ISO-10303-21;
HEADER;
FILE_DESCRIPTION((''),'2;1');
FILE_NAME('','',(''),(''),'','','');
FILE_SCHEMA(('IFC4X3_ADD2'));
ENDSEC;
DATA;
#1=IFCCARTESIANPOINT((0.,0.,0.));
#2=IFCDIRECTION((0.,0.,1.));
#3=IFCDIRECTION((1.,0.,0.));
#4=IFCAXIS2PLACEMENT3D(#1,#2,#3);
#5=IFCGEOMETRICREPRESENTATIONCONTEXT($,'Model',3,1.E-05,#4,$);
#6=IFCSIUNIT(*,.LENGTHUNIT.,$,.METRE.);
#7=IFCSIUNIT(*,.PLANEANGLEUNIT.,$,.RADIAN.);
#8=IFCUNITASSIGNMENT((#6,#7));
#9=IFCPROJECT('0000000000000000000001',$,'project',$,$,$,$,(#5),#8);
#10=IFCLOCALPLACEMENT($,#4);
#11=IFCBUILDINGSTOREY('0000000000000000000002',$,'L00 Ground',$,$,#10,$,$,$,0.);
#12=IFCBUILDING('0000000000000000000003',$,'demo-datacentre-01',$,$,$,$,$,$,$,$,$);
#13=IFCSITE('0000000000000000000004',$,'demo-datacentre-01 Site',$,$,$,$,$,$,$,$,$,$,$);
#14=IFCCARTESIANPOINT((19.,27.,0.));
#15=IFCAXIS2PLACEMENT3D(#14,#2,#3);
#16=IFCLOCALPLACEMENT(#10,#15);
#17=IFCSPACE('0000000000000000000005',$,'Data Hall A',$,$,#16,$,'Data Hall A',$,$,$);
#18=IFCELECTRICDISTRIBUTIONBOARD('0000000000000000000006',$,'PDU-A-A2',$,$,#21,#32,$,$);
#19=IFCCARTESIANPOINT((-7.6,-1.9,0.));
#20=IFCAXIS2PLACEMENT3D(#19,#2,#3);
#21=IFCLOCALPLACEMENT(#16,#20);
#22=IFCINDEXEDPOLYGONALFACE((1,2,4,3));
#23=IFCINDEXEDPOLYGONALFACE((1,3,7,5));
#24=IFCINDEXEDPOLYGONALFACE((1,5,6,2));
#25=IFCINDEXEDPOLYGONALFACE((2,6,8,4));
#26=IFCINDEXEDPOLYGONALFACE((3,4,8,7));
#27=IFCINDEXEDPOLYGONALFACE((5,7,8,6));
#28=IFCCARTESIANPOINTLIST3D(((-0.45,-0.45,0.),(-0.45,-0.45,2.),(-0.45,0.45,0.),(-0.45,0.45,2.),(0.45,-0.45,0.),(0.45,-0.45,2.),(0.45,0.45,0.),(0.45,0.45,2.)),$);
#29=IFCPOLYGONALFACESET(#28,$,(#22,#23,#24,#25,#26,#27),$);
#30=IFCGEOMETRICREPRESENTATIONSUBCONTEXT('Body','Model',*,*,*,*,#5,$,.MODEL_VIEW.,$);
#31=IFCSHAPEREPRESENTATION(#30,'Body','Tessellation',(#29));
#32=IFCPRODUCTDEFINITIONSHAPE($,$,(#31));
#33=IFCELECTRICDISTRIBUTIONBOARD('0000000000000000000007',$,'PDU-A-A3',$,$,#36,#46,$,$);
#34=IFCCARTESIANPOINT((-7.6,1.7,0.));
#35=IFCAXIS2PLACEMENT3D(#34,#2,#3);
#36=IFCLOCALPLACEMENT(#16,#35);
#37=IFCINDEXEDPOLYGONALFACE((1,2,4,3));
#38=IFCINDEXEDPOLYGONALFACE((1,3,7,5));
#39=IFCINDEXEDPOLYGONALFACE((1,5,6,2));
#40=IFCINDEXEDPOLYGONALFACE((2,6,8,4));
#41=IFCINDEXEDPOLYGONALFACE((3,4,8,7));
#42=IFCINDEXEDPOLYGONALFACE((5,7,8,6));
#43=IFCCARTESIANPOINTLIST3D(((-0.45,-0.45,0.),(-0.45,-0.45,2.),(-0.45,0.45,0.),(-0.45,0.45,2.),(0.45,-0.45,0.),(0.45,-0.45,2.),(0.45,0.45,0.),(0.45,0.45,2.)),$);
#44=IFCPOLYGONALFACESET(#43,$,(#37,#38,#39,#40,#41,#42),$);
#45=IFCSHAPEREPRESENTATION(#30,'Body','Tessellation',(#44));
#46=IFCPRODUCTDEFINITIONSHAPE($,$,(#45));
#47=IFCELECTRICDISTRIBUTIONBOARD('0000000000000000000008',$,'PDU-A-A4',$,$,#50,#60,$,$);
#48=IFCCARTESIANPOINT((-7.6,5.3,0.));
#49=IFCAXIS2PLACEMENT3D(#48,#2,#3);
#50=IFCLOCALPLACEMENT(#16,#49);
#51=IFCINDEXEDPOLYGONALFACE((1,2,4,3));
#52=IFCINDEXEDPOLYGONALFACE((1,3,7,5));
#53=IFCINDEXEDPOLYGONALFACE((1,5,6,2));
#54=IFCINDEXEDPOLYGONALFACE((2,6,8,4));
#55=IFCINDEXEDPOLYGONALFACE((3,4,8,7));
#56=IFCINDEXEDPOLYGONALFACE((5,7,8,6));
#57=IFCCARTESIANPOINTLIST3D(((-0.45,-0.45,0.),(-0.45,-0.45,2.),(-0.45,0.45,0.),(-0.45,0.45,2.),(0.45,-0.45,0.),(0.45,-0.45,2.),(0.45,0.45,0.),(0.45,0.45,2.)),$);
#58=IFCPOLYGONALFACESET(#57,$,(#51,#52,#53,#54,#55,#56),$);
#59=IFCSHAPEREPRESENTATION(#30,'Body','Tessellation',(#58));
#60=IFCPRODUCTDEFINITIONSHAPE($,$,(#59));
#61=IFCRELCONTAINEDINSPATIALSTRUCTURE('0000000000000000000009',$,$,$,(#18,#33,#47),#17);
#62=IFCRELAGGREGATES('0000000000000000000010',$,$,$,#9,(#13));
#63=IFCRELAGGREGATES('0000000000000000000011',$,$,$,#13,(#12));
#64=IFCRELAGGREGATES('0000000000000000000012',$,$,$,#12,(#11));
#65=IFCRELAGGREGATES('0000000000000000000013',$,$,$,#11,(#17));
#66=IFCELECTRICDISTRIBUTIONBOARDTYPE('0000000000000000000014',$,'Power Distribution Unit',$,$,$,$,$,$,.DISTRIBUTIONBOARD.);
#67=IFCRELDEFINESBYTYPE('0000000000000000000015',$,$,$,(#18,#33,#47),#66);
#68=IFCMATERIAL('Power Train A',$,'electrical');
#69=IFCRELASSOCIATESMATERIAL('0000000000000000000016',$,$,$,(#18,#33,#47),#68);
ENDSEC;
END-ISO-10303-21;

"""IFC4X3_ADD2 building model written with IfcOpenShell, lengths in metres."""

from ifc_helpers import new_model, si_unit, frame, origin_with_axes, place, context, subcontext, project, spatial, rectangle, extrude, material, type_object, element, save


model = new_model("IFC4X3_ADD2")

# Units and contexts
model_context = context("Model", 3, precision=1e-05, world=origin_with_axes())
body_context = subcontext(model_context, "Body", "Model", "MODEL_VIEW")
ifc_project = project(units=[si_unit("LENGTHUNIT", "METRE"), si_unit("PLANEANGLEUNIT", "RADIAN")], contexts=[model_context])

# Site, building, storey, space
site = spatial("IfcSite", under=ifc_project, Name="demo-datacentre-01 Site")
building = spatial("IfcBuilding", under=site, Name="demo-datacentre-01")
storey_placement = place(None, origin_with_axes())
storey = spatial("IfcBuildingStorey", under=building, at=storey_placement, Name="L00 Ground", Elevation=0.0)
space_placement = place(storey_placement, frame((19.0, 27.0, 0.0), z_axis=(0.0, 0.0, 1.0), x_axis=(1.0, 0.0, 0.0)))
space = spatial("IfcSpace", under=storey, at=space_placement, Name="Data Hall A", LongName="Data Hall A")

# Electric distribution boards
ifc_material_1 = material(Name="Power Train A", Category="electrical")
electric_distribution_board_type = type_object("IfcElectricDistributionBoardType", Name="Power Distribution Unit", PredefinedType="DISTRIBUTIONBOARD")
for number, where, z_axis, x_axis, name in (
    (1, (-7.6, -1.9, 0.0), (0.0, 0.0, 1.0), (1.0, 0.0, 0.0), "PDU-A-A2"),
    (2, (-7.6, 1.7, 0.0), (0.0, 0.0, 1.0), (1.0, 0.0, 0.0), "PDU-A-A3"),
    (3, (-7.6, 5.3, 0.0), (0.0, 0.0, 1.0), (1.0, 0.0, 0.0), "PDU-A-A4"),
):
    element("IfcElectricDistributionBoard", number, at=place(space_placement, frame(where, z_axis=z_axis, x_axis=x_axis)), inside=space, type_object=electric_distribution_board_type, material=ifc_material_1, Name=name, context=body_context, shape_type="SweptSolid", body=[
        extrude(rectangle(XDim=0.9, YDim=0.9), origin_with_axes(), (0.0, 0.0, 1.0), 2.0),
    ])

save(model, "model.ifc")
